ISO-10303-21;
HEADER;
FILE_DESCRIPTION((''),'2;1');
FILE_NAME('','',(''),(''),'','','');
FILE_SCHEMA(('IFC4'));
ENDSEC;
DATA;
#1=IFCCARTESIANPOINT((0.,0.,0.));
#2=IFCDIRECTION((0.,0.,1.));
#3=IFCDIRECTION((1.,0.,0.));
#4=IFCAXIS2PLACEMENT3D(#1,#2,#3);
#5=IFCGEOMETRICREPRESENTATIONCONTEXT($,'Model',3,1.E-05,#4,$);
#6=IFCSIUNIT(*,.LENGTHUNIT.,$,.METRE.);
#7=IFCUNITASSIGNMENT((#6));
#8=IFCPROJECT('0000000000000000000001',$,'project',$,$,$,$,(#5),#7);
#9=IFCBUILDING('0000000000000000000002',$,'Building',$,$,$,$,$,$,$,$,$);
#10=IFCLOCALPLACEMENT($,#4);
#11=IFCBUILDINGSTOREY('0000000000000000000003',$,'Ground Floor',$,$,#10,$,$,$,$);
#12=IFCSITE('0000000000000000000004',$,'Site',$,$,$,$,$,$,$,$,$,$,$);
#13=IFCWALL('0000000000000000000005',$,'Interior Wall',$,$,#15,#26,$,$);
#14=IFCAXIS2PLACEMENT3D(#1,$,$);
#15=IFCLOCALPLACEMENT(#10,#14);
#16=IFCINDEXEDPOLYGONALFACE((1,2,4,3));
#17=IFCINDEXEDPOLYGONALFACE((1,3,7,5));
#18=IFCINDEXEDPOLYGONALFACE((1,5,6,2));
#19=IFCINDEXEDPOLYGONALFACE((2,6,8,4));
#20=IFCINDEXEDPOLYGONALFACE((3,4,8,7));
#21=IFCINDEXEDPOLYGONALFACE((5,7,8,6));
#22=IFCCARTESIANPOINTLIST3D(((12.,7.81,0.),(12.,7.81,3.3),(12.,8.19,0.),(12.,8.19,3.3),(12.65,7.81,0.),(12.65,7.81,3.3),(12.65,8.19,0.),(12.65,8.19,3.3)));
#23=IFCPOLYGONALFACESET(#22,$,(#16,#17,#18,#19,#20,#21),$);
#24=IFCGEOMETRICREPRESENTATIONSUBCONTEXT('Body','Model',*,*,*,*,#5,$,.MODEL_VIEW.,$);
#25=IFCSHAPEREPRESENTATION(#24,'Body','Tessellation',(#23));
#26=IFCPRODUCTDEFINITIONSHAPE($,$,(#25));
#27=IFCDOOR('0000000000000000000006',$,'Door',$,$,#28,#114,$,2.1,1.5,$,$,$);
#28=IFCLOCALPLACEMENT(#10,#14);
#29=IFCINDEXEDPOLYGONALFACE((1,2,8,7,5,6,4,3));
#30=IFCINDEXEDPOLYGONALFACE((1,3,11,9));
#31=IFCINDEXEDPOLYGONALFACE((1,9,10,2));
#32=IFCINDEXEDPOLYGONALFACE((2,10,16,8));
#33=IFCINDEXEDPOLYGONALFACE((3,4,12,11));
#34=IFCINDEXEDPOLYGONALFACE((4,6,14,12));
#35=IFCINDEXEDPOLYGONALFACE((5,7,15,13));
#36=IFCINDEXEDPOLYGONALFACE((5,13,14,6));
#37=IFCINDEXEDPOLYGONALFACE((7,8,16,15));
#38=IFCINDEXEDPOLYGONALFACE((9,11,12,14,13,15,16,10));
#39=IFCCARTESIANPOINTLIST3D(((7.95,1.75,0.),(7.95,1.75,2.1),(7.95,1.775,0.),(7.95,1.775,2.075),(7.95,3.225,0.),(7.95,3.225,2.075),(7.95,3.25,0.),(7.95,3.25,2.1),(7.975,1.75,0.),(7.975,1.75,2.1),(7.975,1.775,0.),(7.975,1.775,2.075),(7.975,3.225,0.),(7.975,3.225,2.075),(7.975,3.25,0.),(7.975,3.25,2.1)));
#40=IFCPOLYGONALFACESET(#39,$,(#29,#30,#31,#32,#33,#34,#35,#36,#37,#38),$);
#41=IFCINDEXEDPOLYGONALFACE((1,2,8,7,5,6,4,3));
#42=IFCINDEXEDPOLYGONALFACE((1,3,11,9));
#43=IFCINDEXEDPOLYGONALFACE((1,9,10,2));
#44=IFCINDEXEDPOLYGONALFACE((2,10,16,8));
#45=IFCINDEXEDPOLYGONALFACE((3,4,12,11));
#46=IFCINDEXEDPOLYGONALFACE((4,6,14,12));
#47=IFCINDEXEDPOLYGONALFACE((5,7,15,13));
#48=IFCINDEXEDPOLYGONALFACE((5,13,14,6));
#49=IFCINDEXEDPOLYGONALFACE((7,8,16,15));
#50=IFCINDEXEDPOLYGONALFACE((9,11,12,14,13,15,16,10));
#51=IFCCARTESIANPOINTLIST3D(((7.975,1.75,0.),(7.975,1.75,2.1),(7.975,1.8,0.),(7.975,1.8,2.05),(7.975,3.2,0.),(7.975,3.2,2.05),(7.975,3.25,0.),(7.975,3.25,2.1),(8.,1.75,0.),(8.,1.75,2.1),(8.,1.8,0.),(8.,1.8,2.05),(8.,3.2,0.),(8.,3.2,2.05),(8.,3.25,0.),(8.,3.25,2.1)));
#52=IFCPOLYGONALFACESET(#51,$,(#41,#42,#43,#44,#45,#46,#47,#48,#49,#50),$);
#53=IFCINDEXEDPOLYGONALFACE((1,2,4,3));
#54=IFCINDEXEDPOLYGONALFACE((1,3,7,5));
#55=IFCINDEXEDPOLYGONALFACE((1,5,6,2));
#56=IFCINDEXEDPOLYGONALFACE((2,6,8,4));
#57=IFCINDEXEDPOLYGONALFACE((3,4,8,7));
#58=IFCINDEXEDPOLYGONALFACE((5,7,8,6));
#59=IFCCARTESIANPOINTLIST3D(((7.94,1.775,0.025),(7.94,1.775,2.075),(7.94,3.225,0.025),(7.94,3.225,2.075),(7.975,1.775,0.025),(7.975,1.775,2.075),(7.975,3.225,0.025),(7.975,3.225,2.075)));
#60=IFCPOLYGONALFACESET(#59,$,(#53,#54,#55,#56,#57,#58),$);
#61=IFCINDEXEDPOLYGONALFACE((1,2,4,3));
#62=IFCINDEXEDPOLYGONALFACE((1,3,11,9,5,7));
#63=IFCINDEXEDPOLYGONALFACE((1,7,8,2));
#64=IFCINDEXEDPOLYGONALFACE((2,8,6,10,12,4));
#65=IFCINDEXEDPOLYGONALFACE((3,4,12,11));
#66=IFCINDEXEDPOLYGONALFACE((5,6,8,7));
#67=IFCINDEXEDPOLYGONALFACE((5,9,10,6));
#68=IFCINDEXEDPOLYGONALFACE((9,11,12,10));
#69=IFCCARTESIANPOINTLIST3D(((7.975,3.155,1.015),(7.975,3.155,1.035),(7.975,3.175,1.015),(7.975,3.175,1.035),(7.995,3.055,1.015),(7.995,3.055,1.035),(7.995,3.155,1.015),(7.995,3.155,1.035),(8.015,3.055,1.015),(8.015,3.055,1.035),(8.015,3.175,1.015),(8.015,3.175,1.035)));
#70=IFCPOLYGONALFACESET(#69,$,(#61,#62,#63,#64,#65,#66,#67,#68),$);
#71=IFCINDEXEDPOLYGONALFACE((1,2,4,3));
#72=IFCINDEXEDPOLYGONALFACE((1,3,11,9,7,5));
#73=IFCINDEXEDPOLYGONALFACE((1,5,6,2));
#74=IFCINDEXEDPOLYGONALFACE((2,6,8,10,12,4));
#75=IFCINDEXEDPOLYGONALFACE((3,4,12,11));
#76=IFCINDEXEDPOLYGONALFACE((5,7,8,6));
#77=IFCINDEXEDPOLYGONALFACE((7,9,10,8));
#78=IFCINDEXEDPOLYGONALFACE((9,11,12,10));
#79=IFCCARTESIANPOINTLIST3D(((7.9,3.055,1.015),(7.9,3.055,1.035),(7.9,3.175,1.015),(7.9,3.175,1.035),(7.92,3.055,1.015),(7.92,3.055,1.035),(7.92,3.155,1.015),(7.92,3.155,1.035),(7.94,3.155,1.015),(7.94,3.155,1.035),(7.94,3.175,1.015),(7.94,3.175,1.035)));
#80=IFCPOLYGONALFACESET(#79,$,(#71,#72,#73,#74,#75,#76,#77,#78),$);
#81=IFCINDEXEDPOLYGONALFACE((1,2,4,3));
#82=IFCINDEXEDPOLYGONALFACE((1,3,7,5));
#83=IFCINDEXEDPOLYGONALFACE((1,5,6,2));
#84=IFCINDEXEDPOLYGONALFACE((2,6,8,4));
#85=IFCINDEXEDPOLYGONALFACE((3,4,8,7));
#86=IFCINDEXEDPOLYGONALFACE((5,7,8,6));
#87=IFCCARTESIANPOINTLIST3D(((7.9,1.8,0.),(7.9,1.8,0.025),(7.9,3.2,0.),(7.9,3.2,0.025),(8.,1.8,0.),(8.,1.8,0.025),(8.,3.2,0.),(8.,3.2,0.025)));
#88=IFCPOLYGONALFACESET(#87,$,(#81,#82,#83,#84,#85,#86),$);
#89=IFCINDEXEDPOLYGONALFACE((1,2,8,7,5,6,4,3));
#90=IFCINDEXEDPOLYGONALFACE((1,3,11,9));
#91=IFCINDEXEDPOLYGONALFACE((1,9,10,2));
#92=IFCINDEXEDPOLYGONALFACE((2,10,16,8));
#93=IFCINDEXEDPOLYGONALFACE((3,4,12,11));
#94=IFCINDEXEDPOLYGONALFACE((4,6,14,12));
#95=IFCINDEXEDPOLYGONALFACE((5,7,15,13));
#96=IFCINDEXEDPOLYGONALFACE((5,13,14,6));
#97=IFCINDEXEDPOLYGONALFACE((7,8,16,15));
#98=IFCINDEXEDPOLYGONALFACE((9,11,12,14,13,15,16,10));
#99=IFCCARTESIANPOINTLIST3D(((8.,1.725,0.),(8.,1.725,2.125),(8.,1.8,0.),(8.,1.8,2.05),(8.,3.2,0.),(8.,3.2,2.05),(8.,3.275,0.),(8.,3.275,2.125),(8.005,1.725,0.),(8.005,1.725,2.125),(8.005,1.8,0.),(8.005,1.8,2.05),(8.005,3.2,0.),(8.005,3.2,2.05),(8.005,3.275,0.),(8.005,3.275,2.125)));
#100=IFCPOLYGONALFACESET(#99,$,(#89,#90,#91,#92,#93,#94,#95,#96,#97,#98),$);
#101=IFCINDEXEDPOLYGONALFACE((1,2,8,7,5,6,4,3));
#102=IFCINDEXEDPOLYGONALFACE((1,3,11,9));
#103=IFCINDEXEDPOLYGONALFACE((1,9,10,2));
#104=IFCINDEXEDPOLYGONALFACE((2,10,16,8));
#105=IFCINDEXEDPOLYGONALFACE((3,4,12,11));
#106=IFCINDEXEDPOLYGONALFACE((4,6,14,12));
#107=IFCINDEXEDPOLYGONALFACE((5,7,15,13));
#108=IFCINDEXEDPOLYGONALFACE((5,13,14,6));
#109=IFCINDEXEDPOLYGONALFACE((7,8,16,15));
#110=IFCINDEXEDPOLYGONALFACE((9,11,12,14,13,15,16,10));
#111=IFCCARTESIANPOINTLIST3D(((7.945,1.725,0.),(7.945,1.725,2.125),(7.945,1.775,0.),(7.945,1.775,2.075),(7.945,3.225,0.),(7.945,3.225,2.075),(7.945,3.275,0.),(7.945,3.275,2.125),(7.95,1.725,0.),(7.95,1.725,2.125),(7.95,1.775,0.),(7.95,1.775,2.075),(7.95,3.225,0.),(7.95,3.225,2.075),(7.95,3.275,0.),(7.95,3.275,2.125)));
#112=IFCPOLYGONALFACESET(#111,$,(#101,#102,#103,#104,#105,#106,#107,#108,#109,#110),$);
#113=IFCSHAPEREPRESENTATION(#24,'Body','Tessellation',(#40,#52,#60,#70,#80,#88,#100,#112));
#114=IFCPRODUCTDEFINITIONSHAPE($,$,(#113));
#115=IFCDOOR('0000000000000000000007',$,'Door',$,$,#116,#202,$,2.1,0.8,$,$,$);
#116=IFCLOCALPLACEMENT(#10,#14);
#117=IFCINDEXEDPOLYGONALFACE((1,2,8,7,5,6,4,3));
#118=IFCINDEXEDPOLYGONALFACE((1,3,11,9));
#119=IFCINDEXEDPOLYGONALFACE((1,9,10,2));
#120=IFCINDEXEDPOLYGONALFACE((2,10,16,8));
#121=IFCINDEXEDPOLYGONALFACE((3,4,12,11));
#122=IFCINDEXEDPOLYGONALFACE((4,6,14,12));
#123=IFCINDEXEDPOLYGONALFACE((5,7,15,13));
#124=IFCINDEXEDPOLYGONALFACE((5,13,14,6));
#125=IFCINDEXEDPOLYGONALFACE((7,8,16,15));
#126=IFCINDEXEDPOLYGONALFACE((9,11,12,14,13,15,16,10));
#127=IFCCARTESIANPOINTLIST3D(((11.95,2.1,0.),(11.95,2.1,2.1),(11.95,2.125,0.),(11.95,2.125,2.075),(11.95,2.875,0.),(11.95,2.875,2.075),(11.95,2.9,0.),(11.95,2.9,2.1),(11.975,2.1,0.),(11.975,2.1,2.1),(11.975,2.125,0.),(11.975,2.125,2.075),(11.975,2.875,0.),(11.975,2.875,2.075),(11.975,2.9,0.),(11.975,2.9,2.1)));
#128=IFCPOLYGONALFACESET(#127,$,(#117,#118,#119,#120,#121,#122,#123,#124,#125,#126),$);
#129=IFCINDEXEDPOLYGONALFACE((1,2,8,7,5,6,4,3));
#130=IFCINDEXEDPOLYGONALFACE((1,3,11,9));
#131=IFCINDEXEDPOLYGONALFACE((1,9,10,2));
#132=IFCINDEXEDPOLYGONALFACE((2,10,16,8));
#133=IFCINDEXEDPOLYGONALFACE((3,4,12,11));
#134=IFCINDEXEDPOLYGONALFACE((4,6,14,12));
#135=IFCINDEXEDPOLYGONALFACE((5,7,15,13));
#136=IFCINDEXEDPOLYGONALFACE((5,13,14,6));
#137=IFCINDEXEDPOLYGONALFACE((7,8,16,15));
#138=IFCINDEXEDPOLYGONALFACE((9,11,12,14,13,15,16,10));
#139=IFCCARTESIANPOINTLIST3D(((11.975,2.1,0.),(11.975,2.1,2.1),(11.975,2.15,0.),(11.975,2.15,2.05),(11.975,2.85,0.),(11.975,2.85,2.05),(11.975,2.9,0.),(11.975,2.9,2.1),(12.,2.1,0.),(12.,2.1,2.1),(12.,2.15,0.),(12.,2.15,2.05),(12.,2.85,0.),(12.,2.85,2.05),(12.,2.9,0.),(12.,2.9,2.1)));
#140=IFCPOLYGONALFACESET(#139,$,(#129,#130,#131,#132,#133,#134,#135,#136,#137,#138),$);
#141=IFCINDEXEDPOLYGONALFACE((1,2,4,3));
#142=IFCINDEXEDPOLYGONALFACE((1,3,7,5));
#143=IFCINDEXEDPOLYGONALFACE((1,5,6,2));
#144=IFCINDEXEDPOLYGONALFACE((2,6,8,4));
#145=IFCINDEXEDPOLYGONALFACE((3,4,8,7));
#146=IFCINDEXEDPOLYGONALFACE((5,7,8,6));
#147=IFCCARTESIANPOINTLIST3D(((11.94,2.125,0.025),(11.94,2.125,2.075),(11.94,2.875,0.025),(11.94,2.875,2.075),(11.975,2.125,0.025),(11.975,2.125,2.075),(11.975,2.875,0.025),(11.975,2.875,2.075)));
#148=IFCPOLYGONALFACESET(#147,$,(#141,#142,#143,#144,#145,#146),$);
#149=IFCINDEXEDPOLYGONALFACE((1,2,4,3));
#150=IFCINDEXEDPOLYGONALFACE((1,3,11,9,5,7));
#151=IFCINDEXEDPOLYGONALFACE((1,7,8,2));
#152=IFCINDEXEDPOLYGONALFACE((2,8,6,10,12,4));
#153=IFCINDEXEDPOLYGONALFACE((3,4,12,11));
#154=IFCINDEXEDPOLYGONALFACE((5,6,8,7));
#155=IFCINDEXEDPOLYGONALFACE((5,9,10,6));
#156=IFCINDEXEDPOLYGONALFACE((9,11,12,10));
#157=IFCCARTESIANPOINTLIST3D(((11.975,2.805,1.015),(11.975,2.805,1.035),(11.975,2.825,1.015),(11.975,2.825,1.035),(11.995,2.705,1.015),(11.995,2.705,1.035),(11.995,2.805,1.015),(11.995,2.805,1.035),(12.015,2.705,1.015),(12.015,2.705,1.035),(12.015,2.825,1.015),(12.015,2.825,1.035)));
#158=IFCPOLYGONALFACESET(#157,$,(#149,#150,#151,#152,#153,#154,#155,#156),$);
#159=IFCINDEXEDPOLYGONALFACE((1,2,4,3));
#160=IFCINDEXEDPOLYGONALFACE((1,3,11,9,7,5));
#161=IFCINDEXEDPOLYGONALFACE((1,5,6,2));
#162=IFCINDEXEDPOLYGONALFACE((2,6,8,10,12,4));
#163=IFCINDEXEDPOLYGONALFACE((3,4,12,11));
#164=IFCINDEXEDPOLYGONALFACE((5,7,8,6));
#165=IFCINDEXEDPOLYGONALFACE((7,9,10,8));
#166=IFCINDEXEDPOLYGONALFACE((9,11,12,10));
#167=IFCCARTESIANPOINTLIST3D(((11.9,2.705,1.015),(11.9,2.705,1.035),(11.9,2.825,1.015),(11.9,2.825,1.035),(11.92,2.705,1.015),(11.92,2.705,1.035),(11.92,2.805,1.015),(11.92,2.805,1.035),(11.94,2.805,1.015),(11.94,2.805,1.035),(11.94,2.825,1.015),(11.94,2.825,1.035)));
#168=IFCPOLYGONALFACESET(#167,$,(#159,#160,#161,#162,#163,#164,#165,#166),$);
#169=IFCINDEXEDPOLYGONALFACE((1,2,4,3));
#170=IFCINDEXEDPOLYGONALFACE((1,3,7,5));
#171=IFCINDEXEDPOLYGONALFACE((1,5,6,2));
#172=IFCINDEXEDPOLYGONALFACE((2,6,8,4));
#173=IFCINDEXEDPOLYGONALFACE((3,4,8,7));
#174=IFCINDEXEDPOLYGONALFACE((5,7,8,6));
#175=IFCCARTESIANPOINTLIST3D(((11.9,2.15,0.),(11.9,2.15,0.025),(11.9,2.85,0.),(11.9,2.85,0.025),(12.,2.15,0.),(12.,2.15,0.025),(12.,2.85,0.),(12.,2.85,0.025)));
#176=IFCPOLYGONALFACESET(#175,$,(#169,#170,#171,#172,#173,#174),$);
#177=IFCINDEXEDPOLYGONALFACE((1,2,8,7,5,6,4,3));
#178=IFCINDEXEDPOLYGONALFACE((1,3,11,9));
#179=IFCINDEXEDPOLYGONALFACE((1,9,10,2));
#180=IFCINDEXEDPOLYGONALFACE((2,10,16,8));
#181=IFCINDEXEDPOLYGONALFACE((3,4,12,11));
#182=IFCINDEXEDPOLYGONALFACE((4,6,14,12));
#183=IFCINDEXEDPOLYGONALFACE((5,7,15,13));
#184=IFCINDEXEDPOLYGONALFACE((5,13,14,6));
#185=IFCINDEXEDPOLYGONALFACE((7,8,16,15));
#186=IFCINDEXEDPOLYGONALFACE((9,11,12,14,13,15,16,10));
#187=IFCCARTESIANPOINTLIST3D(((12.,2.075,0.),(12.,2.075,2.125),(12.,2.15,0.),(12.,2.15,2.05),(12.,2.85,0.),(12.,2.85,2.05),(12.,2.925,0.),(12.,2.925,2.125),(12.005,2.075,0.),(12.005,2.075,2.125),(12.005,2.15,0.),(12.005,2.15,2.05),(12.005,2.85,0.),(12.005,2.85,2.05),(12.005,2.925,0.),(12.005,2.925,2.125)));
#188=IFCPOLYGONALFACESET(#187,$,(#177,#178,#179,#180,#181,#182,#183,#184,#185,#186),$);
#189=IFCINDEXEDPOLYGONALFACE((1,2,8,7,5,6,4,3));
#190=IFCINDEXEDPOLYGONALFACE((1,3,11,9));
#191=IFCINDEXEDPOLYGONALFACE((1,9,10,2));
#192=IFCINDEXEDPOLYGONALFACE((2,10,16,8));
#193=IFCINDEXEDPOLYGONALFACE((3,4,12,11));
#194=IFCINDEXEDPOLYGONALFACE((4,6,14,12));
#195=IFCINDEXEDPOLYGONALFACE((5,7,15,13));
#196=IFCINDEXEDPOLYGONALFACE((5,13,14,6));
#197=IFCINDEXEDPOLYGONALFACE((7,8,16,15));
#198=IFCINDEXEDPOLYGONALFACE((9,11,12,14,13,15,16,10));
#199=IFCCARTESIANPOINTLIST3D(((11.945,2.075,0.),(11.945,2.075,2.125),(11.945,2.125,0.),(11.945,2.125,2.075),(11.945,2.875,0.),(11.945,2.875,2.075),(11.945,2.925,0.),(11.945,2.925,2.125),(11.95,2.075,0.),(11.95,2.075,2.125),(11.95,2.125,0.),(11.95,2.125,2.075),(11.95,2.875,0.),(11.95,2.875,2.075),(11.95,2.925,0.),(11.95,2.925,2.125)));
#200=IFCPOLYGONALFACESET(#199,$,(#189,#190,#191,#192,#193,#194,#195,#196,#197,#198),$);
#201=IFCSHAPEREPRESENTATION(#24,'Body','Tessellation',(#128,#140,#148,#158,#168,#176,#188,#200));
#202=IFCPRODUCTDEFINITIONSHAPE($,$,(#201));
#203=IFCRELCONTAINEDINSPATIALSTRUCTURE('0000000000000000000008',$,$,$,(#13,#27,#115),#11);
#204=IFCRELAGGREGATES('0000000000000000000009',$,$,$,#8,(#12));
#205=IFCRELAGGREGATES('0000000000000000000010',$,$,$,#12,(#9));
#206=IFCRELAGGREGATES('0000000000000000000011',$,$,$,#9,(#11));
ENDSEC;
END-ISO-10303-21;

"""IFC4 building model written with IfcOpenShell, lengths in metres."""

from ifc_helpers import new_model, si_unit, frame, origin_with_axes, place, context, subcontext, project, spatial, line, indexed_curve, outline, extrude, element, save


model = new_model("IFC4")

# Units and contexts
model_context = context("Model", 3, precision=1e-05, world=origin_with_axes())
body_context = subcontext(model_context, "Body", "Model", "MODEL_VIEW")
ifc_project = project(units=[si_unit("LENGTHUNIT", "METRE")], contexts=[model_context])

# Site, building, storey
site = spatial("IfcSite", under=ifc_project, Name="Site")
building = spatial("IfcBuilding", under=site, Name="Building")
storey_placement = place(None, origin_with_axes())
storey = spatial("IfcBuildingStorey", under=building, at=storey_placement, Name="Ground Floor")

# Wall
for number, where, z_axis, x_axis, name in (
    (1, (12.65, 8.0, 0.0), (0.0, 0.0, 1.0), (-1.0, 0.0, 0.0), "Interior Wall"),
):
    element("IfcWall", number, at=place(storey_placement, frame(where, z_axis=z_axis, x_axis=x_axis)), inside=storey, Name=name, context=body_context, shape_type="SweptSolid", body=[
        extrude(outline(indexed_curve([(0.0, 0.0), (0.0, 0.38), (0.65, 0.38), (0.65, 0.0), (0.0, 0.0)], self_intersect=False)), frame((0.0, -0.19, 0.0), z_axis=(0.0, 0.0, 1.0), x_axis=(1.0, 0.0, 0.0)), (0.0, 0.0, 1.0), 3.3),
    ])

# Doors
door_1_placement = place(storey_placement, frame((8.0, 1.75, 0.0), z_axis=(0.0, 0.0, 1.0), x_axis=(0.0, 1.0, 0.0)))
element("IfcDoor", 2, at=door_1_placement, inside=storey, Name="Door", OverallHeight=2.1, OverallWidth=1.5, context=body_context, shape_type="SweptSolid", body=[
    extrude(outline(indexed_curve([(0.0, 0.0), (0.0, 2.1), (1.5, 2.1), (1.5, 0.0), (1.475, 0.0), (1.475, 2.075), (0.025, 2.075), (0.025, 0.0)], segments=[line(1, 2, 3, 4, 5, 6, 7, 8, 1)])), frame((0.0, 0.025, 0.0), z_axis=(0.0, -1.0, 0.0), x_axis=(1.0, 0.0, 0.0)), (0.0, 0.0, -1.0), 0.025),
    extrude(outline(indexed_curve([(0.0, 0.0), (0.0, 2.1), (1.5, 2.1), (1.5, 0.0), (1.45, 0.0), (1.45, 2.05), (0.05, 2.05), (0.05, 0.0)], segments=[line(1, 2, 3, 4, 5, 6, 7, 8, 1)])), frame((0.0, 0.0, 0.0), z_axis=(0.0, -1.0, 0.0), x_axis=(1.0, 0.0, 0.0)), (0.0, 0.0, -1.0), 0.025),
    extrude(outline(indexed_curve([(0.0, 0.0), (1.45, 0.0), (1.45, 0.035), (0.0, 0.035)], segments=[line(1, 2, 3, 4, 1)])), frame((0.025, 0.025, 0.025), z_axis=(0.0, 0.0, 1.0), x_axis=(1.0, 0.0, 0.0)), (0.0, 0.0, 1.0), 2.05),
    extrude(outline(indexed_curve([(0.0, 0.0), (0.0, -0.04), (-0.12, -0.04), (-0.12, -0.02), (-0.02, -0.02), (-0.02, 0.0)], segments=[line(1, 2, 3, 4, 5, 6, 1)])), frame((1.425, 0.025, 1.015), z_axis=(0.0, 0.0, 1.0), x_axis=(1.0, 0.0, 0.0)), (0.0, 0.0, 1.0), 0.02),
    extrude(outline(indexed_curve([(0.0, 0.0), (0.0, 0.04), (-0.12, 0.04), (-0.12, 0.02), (-0.02, 0.02), (-0.02, 0.0)], segments=[line(1, 2, 3, 4, 5, 6, 1)])), frame((1.425, 0.06, 1.015), z_axis=(0.0, 0.0, 1.0), x_axis=(1.0, 0.0, 0.0)), (0.0, 0.0, 1.0), 0.02),
    extrude(outline(indexed_curve([(0.0, 0.0), (1.4, 0.0), (1.4, 0.1), (0.0, 0.1)], segments=[line(1, 2, 3, 4, 1)])), frame((0.05, 0.0, 0.0), z_axis=(0.0, 0.0, 1.0), x_axis=(1.0, 0.0, 0.0)), (0.0, 0.0, 1.0), 0.025),
    extrude(outline(indexed_curve([(0.0, 0.0), (0.0, 2.125), (1.55, 2.125), (1.55, 0.0), (1.475, 0.0), (1.475, 2.05), (0.075, 2.05), (0.075, 0.0)], segments=[line(1, 2, 3, 4, 5, 6, 7, 8, 1)])), frame((-0.025, -0.005, 0.0), z_axis=(0.0, -1.0, 0.0), x_axis=(1.0, 0.0, 0.0)), (0.0, 0.0, -1.0), 0.005),
    extrude(outline(indexed_curve([(0.0, 0.0), (0.0, 2.125), (1.55, 2.125), (1.55, 0.0), (1.5, 0.0), (1.5, 2.075), (0.05, 2.075), (0.05, 0.0)], segments=[line(1, 2, 3, 4, 5, 6, 7, 8, 1)])), frame((-0.025, 0.05, 0.0), z_axis=(0.0, -1.0, 0.0), x_axis=(1.0, 0.0, 0.0)), (0.0, 0.0, -1.0), 0.005),
])
door_2_placement = place(storey_placement, frame((12.0, 2.1, 0.0), z_axis=(0.0, 0.0, 1.0), x_axis=(0.0, 1.0, 0.0)))
element("IfcDoor", 3, at=door_2_placement, inside=storey, Name="Door", OverallHeight=2.1, OverallWidth=0.8, context=body_context, shape_type="SweptSolid", body=[
    extrude(outline(indexed_curve([(0.0, 0.0), (0.0, 2.1), (0.8, 2.1), (0.8, 0.0), (0.775, 0.0), (0.775, 2.075), (0.025, 2.075), (0.025, 0.0)], segments=[line(1, 2, 3, 4, 5, 6, 7, 8, 1)])), frame((0.0, 0.025, 0.0), z_axis=(0.0, -1.0, 0.0), x_axis=(1.0, 0.0, 0.0)), (0.0, 0.0, -1.0), 0.025),
    extrude(outline(indexed_curve([(0.0, 0.0), (0.0, 2.1), (0.8, 2.1), (0.8, 0.0), (0.75, 0.0), (0.75, 2.05), (0.05, 2.05), (0.05, 0.0)], segments=[line(1, 2, 3, 4, 5, 6, 7, 8, 1)])), frame((0.0, 0.0, 0.0), z_axis=(0.0, -1.0, 0.0), x_axis=(1.0, 0.0, 0.0)), (0.0, 0.0, -1.0), 0.025),
    extrude(outline(indexed_curve([(0.0, 0.0), (0.75, 0.0), (0.75, 0.035), (0.0, 0.035)], segments=[line(1, 2, 3, 4, 1)])), frame((0.025, 0.025, 0.025), z_axis=(0.0, 0.0, 1.0), x_axis=(1.0, 0.0, 0.0)), (0.0, 0.0, 1.0), 2.05),
    extrude(outline(indexed_curve([(0.0, 0.0), (0.0, -0.04), (-0.12, -0.04), (-0.12, -0.02), (-0.02, -0.02), (-0.02, 0.0)], segments=[line(1, 2, 3, 4, 5, 6, 1)])), frame((0.725, 0.025, 1.015), z_axis=(0.0, 0.0, 1.0), x_axis=(1.0, 0.0, 0.0)), (0.0, 0.0, 1.0), 0.02),
    extrude(outline(indexed_curve([(0.0, 0.0), (0.0, 0.04), (-0.12, 0.04), (-0.12, 0.02), (-0.02, 0.02), (-0.02, 0.0)], segments=[line(1, 2, 3, 4, 5, 6, 1)])), frame((0.725, 0.06, 1.015), z_axis=(0.0, 0.0, 1.0), x_axis=(1.0, 0.0, 0.0)), (0.0, 0.0, 1.0), 0.02),
    extrude(outline(indexed_curve([(0.0, 0.0), (0.7, 0.0), (0.7, 0.1), (0.0, 0.1)], segments=[line(1, 2, 3, 4, 1)])), frame((0.05, 0.0, 0.0), z_axis=(0.0, 0.0, 1.0), x_axis=(1.0, 0.0, 0.0)), (0.0, 0.0, 1.0), 0.025),
    extrude(outline(indexed_curve([(0.0, 0.0), (0.0, 2.125), (0.85, 2.125), (0.85, 0.0), (0.775, 0.0), (0.775, 2.05), (0.075, 2.05), (0.075, 0.0)], segments=[line(1, 2, 3, 4, 5, 6, 7, 8, 1)])), frame((-0.025, -0.005, 0.0), z_axis=(0.0, -1.0, 0.0), x_axis=(1.0, 0.0, 0.0)), (0.0, 0.0, -1.0), 0.005),
    extrude(outline(indexed_curve([(0.0, 0.0), (0.0, 2.125), (0.85, 2.125), (0.85, 0.0), (0.8, 0.0), (0.8, 2.075), (0.05, 2.075), (0.05, 0.0)], segments=[line(1, 2, 3, 4, 5, 6, 7, 8, 1)])), frame((-0.025, 0.05, 0.0), z_axis=(0.0, -1.0, 0.0), x_axis=(1.0, 0.0, 0.0)), (0.0, 0.0, -1.0), 0.005),
])

save(model, "model.ifc")
